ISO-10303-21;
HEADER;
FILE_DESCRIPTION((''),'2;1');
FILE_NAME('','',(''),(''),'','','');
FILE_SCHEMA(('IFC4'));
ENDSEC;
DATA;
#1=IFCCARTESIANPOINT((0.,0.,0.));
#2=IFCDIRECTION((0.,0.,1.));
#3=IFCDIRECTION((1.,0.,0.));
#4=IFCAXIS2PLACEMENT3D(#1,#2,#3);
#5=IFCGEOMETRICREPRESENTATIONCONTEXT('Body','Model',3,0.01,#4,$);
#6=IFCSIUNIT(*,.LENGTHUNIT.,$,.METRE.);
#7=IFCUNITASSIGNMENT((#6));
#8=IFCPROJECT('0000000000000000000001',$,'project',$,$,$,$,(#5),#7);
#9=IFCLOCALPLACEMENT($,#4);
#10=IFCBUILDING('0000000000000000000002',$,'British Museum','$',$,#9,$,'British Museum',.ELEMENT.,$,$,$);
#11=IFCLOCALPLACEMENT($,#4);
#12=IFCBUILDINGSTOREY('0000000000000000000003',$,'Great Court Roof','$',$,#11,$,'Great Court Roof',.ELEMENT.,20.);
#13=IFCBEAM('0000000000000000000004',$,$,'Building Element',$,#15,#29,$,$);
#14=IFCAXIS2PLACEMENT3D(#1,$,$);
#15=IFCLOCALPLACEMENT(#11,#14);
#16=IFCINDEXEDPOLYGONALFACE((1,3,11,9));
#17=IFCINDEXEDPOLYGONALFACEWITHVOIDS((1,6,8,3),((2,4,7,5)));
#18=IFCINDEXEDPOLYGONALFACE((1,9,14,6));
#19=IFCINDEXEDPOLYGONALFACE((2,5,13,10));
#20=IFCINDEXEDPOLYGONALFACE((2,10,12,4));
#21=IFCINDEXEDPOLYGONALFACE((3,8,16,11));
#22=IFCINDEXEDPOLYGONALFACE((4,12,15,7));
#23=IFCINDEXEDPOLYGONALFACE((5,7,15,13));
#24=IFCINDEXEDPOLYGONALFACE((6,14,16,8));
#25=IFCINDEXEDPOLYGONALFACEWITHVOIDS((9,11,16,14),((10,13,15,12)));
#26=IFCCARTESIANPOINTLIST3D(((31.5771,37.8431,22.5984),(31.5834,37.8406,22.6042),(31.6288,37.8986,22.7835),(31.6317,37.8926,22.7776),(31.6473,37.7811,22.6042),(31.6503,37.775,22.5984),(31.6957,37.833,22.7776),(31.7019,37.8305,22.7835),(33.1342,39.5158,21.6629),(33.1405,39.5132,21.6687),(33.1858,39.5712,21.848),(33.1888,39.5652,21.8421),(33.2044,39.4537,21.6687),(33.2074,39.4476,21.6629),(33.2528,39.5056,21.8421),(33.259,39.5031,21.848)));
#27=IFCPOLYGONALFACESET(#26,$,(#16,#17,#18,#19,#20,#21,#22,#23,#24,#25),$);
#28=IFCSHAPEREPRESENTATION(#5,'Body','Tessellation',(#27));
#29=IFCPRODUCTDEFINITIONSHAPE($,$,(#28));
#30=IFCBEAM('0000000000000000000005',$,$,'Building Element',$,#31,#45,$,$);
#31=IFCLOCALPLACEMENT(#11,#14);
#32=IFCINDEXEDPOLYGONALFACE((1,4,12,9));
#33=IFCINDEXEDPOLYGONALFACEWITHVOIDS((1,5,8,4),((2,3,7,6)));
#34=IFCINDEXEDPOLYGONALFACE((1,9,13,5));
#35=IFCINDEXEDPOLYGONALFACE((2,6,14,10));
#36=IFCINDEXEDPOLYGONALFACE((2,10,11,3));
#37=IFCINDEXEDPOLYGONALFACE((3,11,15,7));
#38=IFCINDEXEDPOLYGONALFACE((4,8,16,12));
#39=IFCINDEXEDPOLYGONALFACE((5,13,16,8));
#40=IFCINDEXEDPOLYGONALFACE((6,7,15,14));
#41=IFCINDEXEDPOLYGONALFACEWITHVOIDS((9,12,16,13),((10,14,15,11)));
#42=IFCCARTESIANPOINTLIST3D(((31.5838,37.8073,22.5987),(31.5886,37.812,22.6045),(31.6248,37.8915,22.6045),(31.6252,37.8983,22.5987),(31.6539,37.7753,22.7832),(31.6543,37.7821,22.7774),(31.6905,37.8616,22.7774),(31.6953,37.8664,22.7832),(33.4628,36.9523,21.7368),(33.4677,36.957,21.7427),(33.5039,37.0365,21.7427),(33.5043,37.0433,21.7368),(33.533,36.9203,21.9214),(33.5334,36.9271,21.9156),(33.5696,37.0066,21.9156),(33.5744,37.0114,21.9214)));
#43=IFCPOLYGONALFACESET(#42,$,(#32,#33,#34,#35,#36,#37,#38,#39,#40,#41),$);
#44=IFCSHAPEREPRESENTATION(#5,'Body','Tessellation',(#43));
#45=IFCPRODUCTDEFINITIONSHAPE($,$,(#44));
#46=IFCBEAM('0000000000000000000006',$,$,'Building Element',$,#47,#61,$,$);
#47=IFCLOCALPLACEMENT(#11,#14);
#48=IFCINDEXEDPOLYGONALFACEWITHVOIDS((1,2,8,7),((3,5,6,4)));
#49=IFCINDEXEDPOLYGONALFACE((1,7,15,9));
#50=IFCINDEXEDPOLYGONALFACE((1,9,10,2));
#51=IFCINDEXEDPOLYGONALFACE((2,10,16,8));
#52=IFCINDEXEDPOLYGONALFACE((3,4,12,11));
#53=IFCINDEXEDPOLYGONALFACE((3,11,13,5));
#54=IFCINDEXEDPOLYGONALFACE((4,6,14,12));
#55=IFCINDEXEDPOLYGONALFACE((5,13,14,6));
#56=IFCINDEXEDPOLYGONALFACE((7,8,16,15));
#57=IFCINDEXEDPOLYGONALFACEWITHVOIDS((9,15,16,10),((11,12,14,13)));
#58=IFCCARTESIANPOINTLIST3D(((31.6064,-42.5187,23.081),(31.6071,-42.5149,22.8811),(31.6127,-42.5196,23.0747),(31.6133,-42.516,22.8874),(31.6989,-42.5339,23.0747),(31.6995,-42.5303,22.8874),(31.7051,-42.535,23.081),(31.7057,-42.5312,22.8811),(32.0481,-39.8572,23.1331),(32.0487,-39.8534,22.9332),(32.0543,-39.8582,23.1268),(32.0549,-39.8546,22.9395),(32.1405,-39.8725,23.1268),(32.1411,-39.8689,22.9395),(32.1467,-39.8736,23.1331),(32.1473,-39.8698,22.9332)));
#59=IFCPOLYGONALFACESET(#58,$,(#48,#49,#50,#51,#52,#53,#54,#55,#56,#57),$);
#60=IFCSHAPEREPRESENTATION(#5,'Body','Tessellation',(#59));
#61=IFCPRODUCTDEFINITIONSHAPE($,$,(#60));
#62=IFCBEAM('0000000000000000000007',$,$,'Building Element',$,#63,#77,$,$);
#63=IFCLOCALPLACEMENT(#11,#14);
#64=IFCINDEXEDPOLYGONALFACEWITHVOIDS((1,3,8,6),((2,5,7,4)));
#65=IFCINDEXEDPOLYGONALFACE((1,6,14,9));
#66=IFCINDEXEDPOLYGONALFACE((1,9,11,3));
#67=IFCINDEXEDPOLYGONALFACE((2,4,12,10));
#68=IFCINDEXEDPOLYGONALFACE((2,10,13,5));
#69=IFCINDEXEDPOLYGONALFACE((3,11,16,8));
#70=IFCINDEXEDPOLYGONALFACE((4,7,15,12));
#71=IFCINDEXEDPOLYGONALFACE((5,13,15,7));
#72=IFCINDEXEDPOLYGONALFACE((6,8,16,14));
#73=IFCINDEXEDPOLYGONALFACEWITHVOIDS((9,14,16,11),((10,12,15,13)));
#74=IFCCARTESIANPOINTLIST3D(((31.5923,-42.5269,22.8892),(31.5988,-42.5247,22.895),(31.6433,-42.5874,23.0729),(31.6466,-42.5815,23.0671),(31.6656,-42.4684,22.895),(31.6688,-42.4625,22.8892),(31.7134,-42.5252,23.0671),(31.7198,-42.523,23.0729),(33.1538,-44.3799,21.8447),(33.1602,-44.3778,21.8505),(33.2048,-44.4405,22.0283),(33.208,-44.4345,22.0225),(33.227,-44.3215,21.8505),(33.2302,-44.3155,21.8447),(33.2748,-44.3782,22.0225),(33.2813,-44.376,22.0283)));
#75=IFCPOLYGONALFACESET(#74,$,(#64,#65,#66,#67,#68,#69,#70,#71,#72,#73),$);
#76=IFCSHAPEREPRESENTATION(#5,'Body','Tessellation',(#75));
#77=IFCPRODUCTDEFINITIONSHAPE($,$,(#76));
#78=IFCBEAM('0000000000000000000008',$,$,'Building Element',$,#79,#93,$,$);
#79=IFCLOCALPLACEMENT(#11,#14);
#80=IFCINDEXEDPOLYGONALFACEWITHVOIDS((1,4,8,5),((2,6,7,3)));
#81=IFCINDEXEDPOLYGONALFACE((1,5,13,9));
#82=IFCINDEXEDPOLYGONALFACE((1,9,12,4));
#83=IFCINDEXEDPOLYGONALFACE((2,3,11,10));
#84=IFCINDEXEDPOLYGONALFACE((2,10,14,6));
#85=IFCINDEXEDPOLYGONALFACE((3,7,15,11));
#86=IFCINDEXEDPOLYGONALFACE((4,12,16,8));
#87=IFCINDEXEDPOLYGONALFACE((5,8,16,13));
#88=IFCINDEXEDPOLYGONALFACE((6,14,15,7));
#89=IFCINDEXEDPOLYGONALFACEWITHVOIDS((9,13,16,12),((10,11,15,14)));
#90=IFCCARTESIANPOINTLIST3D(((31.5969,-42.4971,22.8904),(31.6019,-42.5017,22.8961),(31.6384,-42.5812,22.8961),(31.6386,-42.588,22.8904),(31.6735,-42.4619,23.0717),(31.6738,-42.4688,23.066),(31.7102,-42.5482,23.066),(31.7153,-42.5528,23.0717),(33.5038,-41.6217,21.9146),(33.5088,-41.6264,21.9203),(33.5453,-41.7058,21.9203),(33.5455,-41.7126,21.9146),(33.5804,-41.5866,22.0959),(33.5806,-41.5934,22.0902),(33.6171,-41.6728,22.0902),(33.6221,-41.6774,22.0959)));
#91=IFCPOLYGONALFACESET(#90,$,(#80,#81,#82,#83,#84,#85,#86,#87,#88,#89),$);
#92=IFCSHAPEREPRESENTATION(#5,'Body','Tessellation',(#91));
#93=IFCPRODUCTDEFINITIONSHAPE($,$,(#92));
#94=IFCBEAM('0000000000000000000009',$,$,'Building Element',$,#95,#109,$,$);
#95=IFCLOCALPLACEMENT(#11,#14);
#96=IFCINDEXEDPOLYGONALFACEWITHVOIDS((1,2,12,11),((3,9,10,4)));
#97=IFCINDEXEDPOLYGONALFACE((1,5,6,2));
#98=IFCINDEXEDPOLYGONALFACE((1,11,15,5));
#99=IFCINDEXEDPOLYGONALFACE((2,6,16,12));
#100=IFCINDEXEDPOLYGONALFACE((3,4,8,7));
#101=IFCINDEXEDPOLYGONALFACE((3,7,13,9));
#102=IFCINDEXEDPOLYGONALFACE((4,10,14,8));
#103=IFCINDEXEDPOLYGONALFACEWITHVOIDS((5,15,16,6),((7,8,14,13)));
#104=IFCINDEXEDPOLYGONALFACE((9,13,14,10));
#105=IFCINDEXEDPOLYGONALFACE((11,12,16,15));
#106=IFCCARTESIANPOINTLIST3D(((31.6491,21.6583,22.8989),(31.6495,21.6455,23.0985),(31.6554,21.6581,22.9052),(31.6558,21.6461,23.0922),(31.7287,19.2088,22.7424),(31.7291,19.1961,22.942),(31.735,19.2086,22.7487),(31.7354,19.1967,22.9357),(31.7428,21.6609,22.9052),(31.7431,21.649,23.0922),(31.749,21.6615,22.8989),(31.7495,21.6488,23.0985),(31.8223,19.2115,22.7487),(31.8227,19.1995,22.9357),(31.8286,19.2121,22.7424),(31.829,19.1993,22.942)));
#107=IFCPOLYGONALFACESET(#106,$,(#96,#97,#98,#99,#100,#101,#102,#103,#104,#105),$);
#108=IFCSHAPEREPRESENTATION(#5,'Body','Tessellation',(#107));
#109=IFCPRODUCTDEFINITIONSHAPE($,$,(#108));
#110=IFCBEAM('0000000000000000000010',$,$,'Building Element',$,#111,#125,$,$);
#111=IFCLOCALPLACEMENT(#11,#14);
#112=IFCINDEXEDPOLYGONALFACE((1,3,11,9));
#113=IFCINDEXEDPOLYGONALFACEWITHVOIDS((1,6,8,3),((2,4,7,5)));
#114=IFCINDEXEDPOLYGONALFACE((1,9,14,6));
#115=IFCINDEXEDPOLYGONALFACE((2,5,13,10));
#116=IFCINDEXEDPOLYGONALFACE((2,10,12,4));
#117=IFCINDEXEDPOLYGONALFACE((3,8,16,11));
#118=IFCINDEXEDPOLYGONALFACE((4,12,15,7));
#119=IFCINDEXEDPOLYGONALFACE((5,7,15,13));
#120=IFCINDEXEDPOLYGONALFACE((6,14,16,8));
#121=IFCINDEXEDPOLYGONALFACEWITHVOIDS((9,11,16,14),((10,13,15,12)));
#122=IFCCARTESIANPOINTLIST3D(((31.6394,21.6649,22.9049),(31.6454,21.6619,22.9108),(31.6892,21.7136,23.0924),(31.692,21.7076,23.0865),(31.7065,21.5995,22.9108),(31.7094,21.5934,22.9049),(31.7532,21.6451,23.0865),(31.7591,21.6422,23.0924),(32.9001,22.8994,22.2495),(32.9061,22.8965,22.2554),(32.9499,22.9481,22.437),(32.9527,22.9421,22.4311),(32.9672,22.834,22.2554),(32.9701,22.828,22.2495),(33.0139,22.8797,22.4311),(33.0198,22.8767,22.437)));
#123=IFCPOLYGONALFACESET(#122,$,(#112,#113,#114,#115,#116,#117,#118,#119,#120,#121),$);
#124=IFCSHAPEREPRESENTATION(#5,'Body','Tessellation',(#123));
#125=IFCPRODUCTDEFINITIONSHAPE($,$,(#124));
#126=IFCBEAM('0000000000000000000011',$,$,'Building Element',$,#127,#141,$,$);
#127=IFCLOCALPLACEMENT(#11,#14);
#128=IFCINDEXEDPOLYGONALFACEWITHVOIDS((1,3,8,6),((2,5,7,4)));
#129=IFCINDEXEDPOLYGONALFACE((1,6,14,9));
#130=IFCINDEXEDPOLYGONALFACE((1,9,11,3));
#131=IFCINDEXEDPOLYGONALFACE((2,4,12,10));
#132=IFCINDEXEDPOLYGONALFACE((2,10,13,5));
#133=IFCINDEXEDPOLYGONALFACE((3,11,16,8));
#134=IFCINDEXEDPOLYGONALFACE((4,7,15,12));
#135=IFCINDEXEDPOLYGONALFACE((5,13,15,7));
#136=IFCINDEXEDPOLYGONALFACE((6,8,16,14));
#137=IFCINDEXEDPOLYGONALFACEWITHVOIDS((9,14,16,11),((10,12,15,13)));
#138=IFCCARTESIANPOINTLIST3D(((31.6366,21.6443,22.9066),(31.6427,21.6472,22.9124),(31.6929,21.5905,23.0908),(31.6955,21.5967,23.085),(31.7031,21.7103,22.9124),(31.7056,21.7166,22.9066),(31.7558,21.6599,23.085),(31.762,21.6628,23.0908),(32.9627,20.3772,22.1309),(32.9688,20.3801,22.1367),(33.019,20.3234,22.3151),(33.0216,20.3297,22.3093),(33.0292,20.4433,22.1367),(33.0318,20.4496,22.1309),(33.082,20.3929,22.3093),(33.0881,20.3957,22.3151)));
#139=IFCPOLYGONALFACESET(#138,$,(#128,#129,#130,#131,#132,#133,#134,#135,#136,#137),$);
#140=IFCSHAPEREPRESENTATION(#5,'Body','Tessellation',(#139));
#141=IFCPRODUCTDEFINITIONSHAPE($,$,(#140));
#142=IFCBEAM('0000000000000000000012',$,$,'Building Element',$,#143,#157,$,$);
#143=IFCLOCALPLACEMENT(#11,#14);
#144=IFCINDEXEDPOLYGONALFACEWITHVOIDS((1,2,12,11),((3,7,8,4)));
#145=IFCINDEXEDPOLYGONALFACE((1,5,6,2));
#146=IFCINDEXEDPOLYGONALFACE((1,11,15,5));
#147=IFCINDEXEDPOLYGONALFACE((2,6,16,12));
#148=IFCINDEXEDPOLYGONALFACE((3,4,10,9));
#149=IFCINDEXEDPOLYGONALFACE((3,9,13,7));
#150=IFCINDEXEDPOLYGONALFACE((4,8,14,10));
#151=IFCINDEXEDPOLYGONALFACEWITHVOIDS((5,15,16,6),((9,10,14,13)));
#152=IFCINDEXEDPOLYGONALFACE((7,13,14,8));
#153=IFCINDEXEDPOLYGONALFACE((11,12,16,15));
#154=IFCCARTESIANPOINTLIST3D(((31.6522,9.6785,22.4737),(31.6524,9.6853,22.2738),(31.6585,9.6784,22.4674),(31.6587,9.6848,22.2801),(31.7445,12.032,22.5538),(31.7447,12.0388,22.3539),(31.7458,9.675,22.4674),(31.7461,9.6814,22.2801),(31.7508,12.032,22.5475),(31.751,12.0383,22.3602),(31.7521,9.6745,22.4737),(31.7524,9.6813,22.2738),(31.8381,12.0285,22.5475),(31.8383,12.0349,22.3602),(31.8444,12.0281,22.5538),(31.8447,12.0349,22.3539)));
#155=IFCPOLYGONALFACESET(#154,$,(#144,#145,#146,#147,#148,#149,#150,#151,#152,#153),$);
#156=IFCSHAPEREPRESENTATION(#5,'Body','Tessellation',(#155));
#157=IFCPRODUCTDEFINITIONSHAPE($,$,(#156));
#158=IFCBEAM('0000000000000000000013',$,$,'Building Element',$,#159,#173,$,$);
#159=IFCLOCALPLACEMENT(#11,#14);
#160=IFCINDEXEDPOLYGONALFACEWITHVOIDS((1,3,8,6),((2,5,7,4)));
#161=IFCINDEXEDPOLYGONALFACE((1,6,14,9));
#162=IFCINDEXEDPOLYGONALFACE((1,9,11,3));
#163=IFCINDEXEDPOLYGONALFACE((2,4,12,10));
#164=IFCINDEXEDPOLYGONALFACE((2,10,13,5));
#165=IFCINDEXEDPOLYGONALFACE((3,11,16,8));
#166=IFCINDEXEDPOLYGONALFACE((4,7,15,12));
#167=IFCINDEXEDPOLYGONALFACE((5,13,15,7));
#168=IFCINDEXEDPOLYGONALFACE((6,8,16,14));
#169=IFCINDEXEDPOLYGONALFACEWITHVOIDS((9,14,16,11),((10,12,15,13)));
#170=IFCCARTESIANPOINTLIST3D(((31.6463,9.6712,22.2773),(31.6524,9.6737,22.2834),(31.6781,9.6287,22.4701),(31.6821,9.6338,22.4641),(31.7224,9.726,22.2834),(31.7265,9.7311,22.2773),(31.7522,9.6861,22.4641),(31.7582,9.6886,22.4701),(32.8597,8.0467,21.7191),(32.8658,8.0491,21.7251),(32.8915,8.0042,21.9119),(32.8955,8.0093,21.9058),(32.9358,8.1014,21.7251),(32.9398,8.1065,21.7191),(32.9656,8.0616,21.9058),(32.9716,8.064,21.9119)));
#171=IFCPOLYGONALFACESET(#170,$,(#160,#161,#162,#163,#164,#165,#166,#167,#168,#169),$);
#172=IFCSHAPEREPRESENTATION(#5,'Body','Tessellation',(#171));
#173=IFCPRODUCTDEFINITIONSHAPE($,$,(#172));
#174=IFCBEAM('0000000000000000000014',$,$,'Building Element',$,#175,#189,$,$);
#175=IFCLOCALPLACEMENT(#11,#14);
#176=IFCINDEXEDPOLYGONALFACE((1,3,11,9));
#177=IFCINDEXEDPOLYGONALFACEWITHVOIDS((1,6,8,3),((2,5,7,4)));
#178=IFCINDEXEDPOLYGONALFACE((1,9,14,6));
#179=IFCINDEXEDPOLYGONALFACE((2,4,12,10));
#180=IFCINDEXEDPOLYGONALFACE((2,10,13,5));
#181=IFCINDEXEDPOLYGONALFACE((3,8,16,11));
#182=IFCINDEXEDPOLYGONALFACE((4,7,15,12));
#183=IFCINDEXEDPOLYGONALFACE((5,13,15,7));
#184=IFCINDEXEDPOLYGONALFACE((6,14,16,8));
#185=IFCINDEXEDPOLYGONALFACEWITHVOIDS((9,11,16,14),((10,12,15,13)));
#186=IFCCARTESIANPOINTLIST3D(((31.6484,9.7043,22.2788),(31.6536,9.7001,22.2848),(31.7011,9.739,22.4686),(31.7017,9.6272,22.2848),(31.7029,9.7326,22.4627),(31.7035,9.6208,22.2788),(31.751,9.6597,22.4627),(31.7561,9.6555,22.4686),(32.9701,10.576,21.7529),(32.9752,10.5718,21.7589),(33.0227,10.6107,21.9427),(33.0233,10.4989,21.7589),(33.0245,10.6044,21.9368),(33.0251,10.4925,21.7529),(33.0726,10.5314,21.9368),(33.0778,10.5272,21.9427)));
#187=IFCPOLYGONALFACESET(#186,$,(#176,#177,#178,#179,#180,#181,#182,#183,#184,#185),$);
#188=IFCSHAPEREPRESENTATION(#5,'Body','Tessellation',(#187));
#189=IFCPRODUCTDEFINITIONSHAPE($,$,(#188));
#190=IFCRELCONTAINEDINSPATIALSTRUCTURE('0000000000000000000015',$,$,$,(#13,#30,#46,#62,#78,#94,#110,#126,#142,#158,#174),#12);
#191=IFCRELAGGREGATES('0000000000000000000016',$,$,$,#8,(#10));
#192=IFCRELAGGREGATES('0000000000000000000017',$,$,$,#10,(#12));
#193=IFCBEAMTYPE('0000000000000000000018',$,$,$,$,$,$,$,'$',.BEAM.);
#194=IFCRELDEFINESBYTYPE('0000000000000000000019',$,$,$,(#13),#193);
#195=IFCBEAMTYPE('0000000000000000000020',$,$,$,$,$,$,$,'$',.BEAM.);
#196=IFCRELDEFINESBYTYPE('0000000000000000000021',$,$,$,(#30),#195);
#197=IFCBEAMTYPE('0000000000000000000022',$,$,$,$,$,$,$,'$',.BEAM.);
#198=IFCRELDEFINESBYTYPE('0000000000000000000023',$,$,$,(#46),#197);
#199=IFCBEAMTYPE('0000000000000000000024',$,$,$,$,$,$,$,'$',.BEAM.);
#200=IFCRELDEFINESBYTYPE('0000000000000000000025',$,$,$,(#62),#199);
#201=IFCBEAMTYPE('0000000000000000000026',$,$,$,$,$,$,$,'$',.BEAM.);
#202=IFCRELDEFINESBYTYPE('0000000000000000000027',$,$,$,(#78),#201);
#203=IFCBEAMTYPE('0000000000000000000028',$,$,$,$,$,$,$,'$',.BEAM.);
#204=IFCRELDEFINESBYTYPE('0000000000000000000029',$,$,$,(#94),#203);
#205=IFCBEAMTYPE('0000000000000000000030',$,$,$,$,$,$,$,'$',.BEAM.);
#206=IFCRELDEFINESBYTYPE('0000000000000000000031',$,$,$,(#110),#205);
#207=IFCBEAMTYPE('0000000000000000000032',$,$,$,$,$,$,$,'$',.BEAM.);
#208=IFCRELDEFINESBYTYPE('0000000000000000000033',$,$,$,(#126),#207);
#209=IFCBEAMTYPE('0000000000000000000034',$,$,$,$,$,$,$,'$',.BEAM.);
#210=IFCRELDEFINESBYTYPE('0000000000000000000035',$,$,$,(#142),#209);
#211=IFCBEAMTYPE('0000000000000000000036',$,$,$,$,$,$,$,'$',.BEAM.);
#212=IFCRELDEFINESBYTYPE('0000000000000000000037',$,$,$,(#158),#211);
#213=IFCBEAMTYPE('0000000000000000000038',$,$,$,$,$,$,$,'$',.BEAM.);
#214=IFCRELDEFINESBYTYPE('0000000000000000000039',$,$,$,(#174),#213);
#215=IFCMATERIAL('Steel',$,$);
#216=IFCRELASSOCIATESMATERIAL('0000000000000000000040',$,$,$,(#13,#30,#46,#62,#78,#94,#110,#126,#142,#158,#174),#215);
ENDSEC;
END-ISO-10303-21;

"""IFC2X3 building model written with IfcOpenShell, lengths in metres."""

from ifc_helpers import new_model, si_unit, frame, origin_with_axes, origin_2d, place, context, project, spatial, hollow_rectangle, extrude, material, type_object, element, save


model = new_model("IFC2X3")

# Units and contexts
model_context = context("Model", 3, precision=0.01, world=origin_with_axes(), identifier="Body")
ifc_project = project(units=[si_unit("LENGTHUNIT", "METRE")], contexts=[model_context])

# Building, storey
building_placement = place(None, origin_with_axes())
building = spatial("IfcBuilding", under=ifc_project, at=building_placement, Name="British Museum", Description="$", LongName="British Museum", CompositionType="ELEMENT")
storey_placement = place(None, origin_with_axes())
storey = spatial("IfcBuildingStorey", under=building, at=storey_placement, Name="Great Court Roof", Description="$", LongName="Great Court Roof", CompositionType="ELEMENT", Elevation=20.0)

# Beams
ifc_material = material(Name="Steel")
beam_type_1 = type_object("IfcBeamType", ElementType="$", PredefinedType="BEAM")
beam_1_placement = place(None, origin_with_axes())
element("IfcBeam", 1, at=beam_1_placement, inside=storey, type_object=beam_type_1, material=ifc_material, Description="Building Element", context=model_context, shape_type="SweptSolid", body=[
    extrude(hollow_rectangle(XDim=0.1, YDim=0.2, WallThickness=0.0063, InnerFilletRadius=0.0, OuterFilletRadius=0.0, at=origin_2d()), frame((31.6395, 37.8368, 22.6909), z_axis=(0.630582, 0.677369, -0.378864), x_axis=(-0.731933, 0.681377, 0.0)), (0.0, 0.0, 1.0), 2.4693),
])
beam_type_2 = type_object("IfcBeamType", ElementType="$", PredefinedType="BEAM")
beam_2_placement = place(None, origin_with_axes())
element("IfcBeam", 2, at=beam_2_placement, inside=storey, type_object=beam_type_2, material=ifc_material, Description="Building Element", context=model_context, shape_type="SweptSolid", body=[
    extrude(hollow_rectangle(XDim=0.1, YDim=0.2, WallThickness=0.0063, InnerFilletRadius=0.0, OuterFilletRadius=0.0, at=origin_2d()), frame((31.6395, 37.8368, 22.6909), z_axis=(0.839957, -0.382189, -0.385233), x_axis=(0.414154, 0.910207, 0.0)), (0.0, 0.0, 1.0), 2.2371),
])
beam_type_3 = type_object("IfcBeamType", ElementType="$", PredefinedType="BEAM")
beam_3_placement = place(None, origin_with_axes())
element("IfcBeam", 3, at=beam_3_placement, inside=storey, type_object=beam_type_3, material=ifc_material, Description="Building Element", context=model_context, shape_type="SweptSolid", body=[
    extrude(hollow_rectangle(XDim=0.1, YDim=0.2, WallThickness=0.0063, InnerFilletRadius=0.0, OuterFilletRadius=0.0, at=origin_2d()), frame((31.6561, -42.525, 22.981), z_axis=(0.163664, 0.986327, 0.019305), x_axis=(-0.986511, 0.163694, 0.0)), (0.0, 0.0, 1.0), 2.6983),
])
beam_type_4 = type_object("IfcBeamType", ElementType="$", PredefinedType="BEAM")
beam_4_placement = place(None, origin_with_axes())
element("IfcBeam", 4, at=beam_4_placement, inside=storey, type_object=beam_type_4, material=ifc_material, Description="Building Element", context=model_context, shape_type="SweptSolid", body=[
    extrude(hollow_rectangle(XDim=0.1, YDim=0.2, WallThickness=0.0063, InnerFilletRadius=0.0, OuterFilletRadius=0.0, at=origin_2d()), frame((31.6561, -42.525, 22.981), z_axis=(0.591741, -0.702243, -0.395851), x_axis=(0.764708, 0.644377, 0.0)), (0.0, 0.0, 1.0), 2.6387),
])
beam_type_5 = type_object("IfcBeamType", ElementType="$", PredefinedType="BEAM")
beam_5_placement = place(None, origin_with_axes())
element("IfcBeam", 5, at=beam_5_placement, inside=storey, type_object=beam_type_5, material=ifc_material, Description="Building Element", context=model_context, shape_type="SweptSolid", body=[
    extrude(hollow_rectangle(XDim=0.1, YDim=0.2, WallThickness=0.0063, InnerFilletRadius=0.0, OuterFilletRadius=0.0, at=origin_2d()), frame((31.6561, -42.525, 22.981), z_axis=(0.824056, 0.378292, -0.421696), x_axis=(-0.417201, 0.908814, 0.0)), (0.0, 0.0, 1.0), 2.314),
])
beam_type_6 = type_object("IfcBeamType", ElementType="$", PredefinedType="BEAM")
beam_6_placement = place(None, origin_with_axes())
element("IfcBeam", 6, at=beam_6_placement, inside=storey, type_object=beam_type_6, material=ifc_material, Description="Building Element", context=model_context, shape_type="SweptSolid", body=[
    extrude(hollow_rectangle(XDim=0.1, YDim=0.2, WallThickness=0.0063, InnerFilletRadius=0.0, OuterFilletRadius=0.0, at=origin_2d()), frame((31.6993, 21.6535, 22.9987), z_axis=(0.032409, -0.997442, -0.063707), x_axis=(0.999473, 0.032475, 0.0)), (0.0, 0.0, 1.0), 2.4557),
])
beam_type_7 = type_object("IfcBeamType", ElementType="$", PredefinedType="BEAM")
beam_7_placement = place(None, origin_with_axes())
element("IfcBeam", 7, at=beam_7_placement, inside=storey, type_object=beam_type_7, material=ifc_material, Description="Building Element", context=model_context, shape_type="SweptSolid", body=[
    extrude(hollow_rectangle(XDim=0.1, YDim=0.2, WallThickness=0.0063, InnerFilletRadius=0.0, OuterFilletRadius=0.0, at=origin_2d()), frame((31.6993, 21.6535, 22.9987), z_axis=(0.669774, 0.655863, -0.348204), x_axis=(-0.699648, 0.714488, 0.0)), (0.0, 0.0, 1.0), 1.8823),
])
beam_type_8 = type_object("IfcBeamType", ElementType="$", PredefinedType="BEAM")
beam_8_placement = place(None, origin_with_axes())
element("IfcBeam", 8, at=beam_8_placement, inside=storey, type_object=beam_type_8, material=ifc_material, Description="Building Element", context=model_context, shape_type="SweptSolid", body=[
    extrude(hollow_rectangle(XDim=0.1, YDim=0.2, WallThickness=0.0063, InnerFilletRadius=0.0, OuterFilletRadius=0.0, at=origin_2d()), frame((31.6993, 21.6535, 22.9987), z_axis=(0.665927, -0.636263, -0.389501), x_axis=(0.69082, 0.723027, 0.0)), (0.0, 0.0, 1.0), 1.9914),
])
beam_type_9 = type_object("IfcBeamType", ElementType="$", PredefinedType="BEAM")
beam_9_placement = place(None, origin_with_axes())
element("IfcBeam", 9, at=beam_9_placement, inside=storey, type_object=beam_type_9, material=ifc_material, Description="Building Element", context=model_context, shape_type="SweptSolid", body=[
    extrude(hollow_rectangle(XDim=0.1, YDim=0.2, WallThickness=0.0063, InnerFilletRadius=0.0, OuterFilletRadius=0.0, at=origin_2d()), frame((31.7023, 9.6799, 22.3737), z_axis=(0.039156, 0.998655, 0.033981), x_axis=(-0.999232, 0.039178, 0.0)), (0.0, 0.0, 1.0), 2.3567),
])
beam_type_10 = type_object("IfcBeamType", ElementType="$", PredefinedType="BEAM")
beam_10_placement = place(None, origin_with_axes())
element("IfcBeam", 10, at=beam_10_placement, inside=storey, type_object=beam_type_10, material=ifc_material, Description="Building Element", context=model_context, shape_type="SweptSolid", body=[
    extrude(hollow_rectangle(XDim=0.1, YDim=0.2, WallThickness=0.0063, InnerFilletRadius=0.0, OuterFilletRadius=0.0, at=origin_2d()), frame((31.7023, 9.6799, 22.3737), z_axis=(0.576945, -0.772448, -0.26544), x_axis=(0.801189, 0.598412, 0.0)), (0.0, 0.0, 1.0), 2.1031),
])
beam_type_11 = type_object("IfcBeamType", ElementType="$", PredefinedType="BEAM")
beam_11_placement = place(None, origin_with_axes())
element("IfcBeam", 11, at=beam_11_placement, inside=storey, type_object=beam_type_11, material=ifc_material, Description="Building Element", context=model_context, shape_type="SweptSolid", body=[
    extrude(hollow_rectangle(XDim=0.1, YDim=0.2, WallThickness=0.0063, InnerFilletRadius=0.0, OuterFilletRadius=0.0, at=origin_2d()), frame((31.7023, 9.6799, 22.3737), z_axis=(0.79221, 0.522527, -0.315229), x_axis=(-0.550599, 0.83477, 0.0)), (0.0, 0.0, 1.0), 1.6683),
])

save(model, "model.ifc")
